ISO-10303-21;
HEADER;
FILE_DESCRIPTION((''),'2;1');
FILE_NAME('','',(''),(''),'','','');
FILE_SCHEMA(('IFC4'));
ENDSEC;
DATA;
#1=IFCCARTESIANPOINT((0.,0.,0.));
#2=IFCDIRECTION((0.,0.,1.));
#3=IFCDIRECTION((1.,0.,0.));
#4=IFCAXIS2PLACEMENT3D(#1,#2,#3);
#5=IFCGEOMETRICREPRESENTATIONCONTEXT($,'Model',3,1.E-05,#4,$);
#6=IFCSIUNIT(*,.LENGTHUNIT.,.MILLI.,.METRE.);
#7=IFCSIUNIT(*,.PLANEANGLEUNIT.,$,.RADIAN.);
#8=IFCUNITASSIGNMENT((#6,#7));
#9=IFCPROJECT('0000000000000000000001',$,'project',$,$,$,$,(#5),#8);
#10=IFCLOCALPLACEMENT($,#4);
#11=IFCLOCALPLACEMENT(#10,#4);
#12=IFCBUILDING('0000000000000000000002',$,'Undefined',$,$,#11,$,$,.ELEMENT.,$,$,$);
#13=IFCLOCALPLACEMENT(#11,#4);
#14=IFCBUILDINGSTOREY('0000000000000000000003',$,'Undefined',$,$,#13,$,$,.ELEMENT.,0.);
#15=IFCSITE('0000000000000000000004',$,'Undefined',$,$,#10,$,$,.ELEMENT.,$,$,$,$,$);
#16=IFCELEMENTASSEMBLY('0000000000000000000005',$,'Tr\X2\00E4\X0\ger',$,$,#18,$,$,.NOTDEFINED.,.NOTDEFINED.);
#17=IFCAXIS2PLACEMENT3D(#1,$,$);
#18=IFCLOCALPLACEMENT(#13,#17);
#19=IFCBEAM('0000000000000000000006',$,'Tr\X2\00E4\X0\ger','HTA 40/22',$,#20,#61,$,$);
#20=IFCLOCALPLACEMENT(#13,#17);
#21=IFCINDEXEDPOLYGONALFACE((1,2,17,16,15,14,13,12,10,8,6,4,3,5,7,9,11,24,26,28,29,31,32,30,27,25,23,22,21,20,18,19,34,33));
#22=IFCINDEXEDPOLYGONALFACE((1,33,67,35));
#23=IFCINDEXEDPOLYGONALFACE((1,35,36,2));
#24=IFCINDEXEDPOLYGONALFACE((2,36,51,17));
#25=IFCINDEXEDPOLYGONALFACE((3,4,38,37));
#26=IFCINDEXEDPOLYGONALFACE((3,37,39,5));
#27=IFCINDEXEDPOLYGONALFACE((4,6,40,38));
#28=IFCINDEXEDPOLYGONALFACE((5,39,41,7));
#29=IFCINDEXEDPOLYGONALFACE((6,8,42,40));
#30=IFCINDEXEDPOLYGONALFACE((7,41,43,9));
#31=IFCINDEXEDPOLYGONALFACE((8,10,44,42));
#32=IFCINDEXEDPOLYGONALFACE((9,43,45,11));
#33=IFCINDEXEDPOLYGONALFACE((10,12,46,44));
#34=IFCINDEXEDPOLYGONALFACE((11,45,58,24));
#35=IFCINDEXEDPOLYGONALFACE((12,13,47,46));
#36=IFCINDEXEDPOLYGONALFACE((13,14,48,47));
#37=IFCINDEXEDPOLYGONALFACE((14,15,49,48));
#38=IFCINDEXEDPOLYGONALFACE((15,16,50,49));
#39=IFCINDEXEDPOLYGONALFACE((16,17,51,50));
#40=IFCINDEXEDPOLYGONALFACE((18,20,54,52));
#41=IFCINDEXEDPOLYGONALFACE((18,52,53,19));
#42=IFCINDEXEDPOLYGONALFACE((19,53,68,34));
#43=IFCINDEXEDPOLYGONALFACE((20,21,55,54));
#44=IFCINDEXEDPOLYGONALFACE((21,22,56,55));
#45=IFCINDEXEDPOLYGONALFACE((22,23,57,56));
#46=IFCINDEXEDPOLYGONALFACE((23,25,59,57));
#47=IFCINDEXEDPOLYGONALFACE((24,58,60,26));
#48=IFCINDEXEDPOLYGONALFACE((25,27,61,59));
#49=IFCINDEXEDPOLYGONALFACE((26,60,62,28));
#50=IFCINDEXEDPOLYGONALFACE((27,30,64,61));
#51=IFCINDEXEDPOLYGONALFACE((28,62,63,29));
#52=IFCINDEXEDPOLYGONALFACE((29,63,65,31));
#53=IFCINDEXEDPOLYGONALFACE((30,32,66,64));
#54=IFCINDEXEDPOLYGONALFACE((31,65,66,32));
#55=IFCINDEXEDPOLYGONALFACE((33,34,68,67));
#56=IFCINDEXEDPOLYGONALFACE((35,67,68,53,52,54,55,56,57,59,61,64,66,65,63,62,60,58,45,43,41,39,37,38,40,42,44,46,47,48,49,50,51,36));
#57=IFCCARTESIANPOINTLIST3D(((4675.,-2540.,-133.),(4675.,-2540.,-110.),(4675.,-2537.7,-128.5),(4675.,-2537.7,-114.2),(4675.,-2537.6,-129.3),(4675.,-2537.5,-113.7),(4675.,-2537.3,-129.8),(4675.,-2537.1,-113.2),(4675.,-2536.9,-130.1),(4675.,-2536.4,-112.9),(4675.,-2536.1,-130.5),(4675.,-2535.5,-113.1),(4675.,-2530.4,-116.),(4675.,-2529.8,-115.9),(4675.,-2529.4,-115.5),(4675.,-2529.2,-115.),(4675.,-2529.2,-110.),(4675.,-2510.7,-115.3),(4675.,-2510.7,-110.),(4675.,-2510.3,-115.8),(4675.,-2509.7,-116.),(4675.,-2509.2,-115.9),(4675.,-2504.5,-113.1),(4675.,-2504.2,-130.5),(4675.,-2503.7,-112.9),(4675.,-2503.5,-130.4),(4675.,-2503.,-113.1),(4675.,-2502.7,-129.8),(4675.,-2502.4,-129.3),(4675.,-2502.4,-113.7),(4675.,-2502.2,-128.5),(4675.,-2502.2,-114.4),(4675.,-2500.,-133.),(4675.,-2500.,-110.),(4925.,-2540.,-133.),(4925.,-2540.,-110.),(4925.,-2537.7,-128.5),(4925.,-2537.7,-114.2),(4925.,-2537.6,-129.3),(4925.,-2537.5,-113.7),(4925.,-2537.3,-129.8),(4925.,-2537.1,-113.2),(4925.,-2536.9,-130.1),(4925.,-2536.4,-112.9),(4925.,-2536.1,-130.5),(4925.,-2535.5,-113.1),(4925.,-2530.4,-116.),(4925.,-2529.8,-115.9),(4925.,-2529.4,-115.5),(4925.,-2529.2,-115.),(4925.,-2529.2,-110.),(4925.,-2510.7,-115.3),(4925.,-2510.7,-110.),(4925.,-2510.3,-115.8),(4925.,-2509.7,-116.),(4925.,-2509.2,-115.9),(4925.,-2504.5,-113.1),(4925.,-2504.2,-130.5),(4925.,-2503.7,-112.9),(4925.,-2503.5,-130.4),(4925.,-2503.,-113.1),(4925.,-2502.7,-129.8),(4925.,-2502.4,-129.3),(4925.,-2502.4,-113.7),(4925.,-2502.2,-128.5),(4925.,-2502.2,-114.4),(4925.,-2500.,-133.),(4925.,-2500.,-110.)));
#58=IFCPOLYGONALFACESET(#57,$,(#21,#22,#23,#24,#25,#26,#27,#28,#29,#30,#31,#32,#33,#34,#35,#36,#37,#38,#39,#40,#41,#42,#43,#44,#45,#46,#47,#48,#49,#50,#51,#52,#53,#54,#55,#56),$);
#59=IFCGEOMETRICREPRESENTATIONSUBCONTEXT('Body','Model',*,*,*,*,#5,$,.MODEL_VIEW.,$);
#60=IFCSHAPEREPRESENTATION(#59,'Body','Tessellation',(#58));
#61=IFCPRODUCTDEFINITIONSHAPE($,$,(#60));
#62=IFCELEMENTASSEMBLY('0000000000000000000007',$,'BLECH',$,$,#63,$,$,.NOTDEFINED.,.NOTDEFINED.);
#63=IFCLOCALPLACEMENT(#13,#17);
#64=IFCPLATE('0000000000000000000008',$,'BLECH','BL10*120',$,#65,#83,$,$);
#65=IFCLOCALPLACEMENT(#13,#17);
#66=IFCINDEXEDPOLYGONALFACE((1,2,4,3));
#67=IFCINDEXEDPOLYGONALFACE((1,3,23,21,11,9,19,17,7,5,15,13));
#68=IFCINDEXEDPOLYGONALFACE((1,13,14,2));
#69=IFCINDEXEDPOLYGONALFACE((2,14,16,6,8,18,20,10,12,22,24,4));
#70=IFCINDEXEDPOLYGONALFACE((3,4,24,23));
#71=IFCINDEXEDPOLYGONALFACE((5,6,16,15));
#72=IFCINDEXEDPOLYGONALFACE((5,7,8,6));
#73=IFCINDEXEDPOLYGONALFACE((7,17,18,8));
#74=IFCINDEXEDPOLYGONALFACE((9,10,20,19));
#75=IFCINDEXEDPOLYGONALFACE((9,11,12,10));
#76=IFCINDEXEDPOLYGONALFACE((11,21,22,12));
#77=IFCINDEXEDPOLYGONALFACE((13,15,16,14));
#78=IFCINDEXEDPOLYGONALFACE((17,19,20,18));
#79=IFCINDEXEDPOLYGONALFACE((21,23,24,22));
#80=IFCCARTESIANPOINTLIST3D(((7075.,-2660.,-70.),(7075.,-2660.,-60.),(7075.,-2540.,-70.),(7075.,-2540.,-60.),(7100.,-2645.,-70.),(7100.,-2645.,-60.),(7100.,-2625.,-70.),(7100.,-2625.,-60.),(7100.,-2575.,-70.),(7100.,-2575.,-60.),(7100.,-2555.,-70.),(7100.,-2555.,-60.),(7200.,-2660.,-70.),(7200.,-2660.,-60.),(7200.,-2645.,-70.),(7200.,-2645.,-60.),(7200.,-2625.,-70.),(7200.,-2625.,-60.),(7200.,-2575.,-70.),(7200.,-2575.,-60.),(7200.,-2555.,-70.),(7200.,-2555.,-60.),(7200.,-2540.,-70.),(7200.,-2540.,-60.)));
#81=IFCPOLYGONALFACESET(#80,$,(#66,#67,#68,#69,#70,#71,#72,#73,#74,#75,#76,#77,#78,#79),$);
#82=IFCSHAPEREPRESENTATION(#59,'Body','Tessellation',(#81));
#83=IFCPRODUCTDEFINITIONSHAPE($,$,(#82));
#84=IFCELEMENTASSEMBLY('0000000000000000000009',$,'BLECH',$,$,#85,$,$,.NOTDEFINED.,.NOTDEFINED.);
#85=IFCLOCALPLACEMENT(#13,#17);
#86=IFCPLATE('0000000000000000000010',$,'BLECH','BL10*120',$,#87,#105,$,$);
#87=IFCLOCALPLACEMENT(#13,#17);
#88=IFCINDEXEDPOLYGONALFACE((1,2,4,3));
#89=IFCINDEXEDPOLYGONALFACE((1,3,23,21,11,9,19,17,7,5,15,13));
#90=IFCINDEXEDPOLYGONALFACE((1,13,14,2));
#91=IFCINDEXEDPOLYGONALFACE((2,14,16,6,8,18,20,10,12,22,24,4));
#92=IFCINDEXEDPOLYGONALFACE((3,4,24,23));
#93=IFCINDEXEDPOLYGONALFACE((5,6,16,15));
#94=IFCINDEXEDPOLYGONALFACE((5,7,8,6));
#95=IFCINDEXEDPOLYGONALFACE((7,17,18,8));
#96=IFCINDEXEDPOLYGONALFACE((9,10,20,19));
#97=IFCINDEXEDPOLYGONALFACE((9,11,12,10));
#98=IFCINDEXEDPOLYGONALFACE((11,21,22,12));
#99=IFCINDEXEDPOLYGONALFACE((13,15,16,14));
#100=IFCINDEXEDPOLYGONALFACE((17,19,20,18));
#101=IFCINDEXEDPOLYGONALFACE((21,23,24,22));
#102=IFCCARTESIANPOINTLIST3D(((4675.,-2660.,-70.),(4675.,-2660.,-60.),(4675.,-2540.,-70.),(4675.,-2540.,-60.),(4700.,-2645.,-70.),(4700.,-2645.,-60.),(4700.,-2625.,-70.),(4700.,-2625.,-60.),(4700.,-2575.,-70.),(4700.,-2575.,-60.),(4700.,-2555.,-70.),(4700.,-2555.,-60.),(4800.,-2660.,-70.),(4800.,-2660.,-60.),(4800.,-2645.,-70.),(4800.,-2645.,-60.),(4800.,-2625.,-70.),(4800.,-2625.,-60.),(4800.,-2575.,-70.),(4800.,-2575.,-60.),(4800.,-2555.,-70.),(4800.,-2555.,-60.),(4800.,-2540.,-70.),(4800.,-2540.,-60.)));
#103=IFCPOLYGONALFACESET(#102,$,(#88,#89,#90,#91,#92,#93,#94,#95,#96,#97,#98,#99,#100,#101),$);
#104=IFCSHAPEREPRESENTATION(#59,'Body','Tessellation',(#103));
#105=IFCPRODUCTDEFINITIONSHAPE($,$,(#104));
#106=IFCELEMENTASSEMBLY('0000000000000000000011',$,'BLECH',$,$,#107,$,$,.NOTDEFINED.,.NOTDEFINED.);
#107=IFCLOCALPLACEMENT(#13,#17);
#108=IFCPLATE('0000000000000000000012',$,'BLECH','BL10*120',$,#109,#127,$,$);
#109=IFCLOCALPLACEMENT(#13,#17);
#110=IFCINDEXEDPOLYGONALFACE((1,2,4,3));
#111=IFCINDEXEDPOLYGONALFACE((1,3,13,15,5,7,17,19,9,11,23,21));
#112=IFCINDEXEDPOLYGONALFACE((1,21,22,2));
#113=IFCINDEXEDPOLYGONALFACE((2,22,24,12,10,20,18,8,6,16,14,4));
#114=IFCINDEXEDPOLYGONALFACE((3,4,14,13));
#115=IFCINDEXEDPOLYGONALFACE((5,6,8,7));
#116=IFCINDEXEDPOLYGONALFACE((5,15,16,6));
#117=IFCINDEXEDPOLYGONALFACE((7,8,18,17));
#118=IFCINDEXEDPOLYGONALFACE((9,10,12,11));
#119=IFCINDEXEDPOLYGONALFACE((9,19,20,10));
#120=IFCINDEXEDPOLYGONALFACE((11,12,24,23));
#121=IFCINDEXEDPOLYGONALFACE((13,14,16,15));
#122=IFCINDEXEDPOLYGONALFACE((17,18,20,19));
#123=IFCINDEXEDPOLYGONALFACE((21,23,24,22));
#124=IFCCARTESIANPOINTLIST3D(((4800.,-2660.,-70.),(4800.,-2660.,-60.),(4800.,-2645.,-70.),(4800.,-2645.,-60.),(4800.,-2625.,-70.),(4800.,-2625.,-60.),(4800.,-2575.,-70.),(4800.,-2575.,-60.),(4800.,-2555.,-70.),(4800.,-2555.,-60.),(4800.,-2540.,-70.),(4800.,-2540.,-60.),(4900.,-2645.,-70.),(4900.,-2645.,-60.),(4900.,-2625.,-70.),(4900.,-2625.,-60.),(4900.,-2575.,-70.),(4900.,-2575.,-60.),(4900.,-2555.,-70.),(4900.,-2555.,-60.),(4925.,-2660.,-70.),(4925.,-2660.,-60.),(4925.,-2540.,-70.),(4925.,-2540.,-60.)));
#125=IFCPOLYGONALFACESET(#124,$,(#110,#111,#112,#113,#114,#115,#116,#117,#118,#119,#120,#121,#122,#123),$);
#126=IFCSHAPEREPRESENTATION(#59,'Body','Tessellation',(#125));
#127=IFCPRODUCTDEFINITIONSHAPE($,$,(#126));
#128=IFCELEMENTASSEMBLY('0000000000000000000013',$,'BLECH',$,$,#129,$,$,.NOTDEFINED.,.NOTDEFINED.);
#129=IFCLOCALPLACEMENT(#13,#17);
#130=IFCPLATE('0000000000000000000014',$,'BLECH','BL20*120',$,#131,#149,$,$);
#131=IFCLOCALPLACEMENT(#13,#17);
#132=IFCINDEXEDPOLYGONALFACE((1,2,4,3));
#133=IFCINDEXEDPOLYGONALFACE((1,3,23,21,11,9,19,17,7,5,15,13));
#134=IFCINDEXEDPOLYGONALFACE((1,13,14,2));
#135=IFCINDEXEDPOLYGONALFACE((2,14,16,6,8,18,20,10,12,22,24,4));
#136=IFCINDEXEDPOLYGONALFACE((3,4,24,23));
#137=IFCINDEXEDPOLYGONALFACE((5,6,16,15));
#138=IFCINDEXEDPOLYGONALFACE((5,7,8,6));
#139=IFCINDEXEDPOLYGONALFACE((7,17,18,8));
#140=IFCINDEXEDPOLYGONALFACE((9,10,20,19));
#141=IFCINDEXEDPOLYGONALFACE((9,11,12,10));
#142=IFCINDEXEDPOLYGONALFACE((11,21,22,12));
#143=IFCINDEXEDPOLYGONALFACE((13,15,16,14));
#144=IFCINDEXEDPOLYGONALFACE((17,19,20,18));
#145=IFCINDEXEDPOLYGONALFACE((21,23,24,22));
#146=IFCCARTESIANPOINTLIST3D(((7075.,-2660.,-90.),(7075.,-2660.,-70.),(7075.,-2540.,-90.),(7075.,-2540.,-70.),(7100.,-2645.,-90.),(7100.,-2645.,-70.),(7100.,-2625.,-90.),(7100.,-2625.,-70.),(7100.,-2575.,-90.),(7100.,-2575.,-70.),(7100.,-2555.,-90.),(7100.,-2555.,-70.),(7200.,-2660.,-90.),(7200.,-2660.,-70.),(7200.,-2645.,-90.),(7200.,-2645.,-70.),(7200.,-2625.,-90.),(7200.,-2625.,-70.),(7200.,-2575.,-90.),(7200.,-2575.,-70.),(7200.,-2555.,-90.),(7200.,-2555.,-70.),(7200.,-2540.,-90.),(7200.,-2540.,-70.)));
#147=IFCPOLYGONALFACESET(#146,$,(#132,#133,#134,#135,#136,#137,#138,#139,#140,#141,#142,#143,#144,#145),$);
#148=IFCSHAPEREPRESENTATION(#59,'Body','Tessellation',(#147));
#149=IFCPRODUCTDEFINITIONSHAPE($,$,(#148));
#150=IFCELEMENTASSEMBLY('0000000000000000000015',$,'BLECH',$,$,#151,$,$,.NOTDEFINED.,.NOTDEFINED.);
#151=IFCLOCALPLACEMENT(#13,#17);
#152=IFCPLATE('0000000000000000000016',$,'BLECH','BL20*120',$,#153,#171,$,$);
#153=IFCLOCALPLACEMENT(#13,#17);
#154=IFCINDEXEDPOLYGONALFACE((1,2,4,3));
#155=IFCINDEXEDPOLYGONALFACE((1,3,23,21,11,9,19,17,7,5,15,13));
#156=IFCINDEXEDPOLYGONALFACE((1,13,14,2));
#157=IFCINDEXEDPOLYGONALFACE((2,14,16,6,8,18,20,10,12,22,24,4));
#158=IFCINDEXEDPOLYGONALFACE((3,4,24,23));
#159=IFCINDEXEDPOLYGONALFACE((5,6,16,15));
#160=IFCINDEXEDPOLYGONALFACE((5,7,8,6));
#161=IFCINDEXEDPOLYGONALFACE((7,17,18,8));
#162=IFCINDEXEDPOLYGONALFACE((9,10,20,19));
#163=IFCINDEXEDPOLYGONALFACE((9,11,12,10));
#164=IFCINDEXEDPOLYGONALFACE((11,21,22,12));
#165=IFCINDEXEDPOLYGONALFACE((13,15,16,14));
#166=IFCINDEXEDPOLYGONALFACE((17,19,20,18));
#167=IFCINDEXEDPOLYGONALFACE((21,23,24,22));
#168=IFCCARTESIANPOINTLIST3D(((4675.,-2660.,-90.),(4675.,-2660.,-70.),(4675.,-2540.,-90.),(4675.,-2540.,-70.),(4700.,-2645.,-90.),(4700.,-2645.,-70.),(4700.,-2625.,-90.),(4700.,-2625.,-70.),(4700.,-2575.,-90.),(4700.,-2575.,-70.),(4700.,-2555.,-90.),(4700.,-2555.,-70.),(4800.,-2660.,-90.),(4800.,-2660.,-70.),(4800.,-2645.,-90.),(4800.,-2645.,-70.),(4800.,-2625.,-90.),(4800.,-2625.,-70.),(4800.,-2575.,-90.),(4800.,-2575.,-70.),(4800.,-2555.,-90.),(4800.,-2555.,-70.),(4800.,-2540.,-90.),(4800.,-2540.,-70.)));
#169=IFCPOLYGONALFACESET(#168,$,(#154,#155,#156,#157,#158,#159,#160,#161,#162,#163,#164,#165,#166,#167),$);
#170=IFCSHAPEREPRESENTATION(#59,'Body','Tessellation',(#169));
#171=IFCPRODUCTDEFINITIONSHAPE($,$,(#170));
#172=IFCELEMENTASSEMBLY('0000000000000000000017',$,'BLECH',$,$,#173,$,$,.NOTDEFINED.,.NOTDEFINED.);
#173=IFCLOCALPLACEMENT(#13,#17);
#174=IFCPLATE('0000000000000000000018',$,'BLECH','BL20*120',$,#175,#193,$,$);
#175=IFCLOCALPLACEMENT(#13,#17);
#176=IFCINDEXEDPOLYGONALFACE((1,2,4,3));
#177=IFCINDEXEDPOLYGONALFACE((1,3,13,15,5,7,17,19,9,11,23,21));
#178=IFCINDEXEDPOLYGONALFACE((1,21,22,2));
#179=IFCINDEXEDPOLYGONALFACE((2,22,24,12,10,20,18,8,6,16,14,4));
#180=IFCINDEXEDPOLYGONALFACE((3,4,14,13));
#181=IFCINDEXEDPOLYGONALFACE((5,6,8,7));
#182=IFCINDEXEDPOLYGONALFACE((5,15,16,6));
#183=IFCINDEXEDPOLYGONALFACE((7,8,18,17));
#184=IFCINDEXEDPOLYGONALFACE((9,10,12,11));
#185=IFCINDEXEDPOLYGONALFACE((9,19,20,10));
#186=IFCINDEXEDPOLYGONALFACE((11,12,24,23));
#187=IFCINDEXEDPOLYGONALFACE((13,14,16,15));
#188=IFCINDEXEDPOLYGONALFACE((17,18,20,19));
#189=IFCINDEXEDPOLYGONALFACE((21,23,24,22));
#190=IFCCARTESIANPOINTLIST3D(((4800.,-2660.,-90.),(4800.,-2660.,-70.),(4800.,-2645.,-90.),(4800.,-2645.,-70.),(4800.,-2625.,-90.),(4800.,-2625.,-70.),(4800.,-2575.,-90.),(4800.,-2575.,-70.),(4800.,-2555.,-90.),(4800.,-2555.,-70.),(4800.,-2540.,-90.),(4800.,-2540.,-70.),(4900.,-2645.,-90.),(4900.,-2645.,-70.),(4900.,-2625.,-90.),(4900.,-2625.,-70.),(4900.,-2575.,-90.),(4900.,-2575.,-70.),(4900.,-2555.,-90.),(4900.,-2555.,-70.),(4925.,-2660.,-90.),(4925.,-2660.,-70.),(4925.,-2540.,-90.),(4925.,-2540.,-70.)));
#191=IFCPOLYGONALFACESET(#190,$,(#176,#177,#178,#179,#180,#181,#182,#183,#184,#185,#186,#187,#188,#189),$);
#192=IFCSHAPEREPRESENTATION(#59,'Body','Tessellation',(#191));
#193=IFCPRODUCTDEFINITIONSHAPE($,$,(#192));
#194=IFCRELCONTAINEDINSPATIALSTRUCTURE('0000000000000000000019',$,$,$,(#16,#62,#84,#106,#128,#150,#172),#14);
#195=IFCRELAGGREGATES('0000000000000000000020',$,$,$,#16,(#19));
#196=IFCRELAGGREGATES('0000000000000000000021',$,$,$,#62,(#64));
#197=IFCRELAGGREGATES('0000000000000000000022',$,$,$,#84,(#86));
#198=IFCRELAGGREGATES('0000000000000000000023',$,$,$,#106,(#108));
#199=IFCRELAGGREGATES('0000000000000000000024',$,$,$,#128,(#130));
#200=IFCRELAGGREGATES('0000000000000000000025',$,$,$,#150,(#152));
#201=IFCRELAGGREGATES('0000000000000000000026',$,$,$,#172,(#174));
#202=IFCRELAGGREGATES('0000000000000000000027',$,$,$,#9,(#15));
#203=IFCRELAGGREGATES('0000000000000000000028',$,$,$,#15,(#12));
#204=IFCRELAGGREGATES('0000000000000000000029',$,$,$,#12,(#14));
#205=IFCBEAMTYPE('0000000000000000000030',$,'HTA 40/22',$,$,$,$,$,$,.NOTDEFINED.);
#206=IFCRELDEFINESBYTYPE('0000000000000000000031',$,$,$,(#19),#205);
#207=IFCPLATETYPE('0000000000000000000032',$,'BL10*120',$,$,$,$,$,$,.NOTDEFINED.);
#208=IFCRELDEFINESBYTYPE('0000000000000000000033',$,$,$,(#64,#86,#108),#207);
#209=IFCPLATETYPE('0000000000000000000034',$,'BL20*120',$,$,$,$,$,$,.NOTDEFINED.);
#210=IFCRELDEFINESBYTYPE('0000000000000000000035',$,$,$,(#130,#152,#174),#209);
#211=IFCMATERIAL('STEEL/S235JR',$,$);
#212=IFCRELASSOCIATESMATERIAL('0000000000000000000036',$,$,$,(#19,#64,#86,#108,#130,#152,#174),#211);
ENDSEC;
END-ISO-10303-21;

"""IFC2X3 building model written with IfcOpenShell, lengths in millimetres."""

from ifc_helpers import new_model, si_unit, frame, origin_with_axes, place, context, subcontext, project, spatial, polyline, outline, extrude, material, type_object, element, aggregate, save


model = new_model("IFC2X3")

# Units and contexts
model_context = context("Model", 3, precision=1e-05, world=origin_with_axes())
body_context = subcontext(model_context, "Body", "Model", "MODEL_VIEW")
ifc_project = project(units=[si_unit("LENGTHUNIT", "METRE", prefix="MILLI"), si_unit("PLANEANGLEUNIT", "RADIAN")], contexts=[model_context])

# Site, building, storey
site_placement = place(None, origin_with_axes())
site = spatial("IfcSite", under=ifc_project, at=site_placement, Name="Undefined", CompositionType="ELEMENT")
building_placement = place(site_placement, origin_with_axes())
building = spatial("IfcBuilding", under=site, at=building_placement, Name="Undefined", CompositionType="ELEMENT")
storey_placement = place(building_placement, origin_with_axes())
storey = spatial("IfcBuildingStorey", under=building, at=storey_placement, Name="Undefined", CompositionType="ELEMENT", Elevation=0.0)

# Element assembly, beam
assembly_1_placement = place(storey_placement, origin_with_axes())
assembly_1 = element("IfcElementAssembly", 1, at=assembly_1_placement, inside=storey, Name="Träger", AssemblyPlace="NOTDEFINED", PredefinedType="NOTDEFINED")
ifc_material = material(Name="STEEL/S235JR")
beam_type = type_object("IfcBeamType", Name="HTA 40/22", PredefinedType="NOTDEFINED")
beam_placement = place(assembly_1_placement, frame((4925.0, -2520.0, -121.5), z_axis=(0.0, 0.0, -1.0), x_axis=(-1.0, 0.0, 0.0)))
beam = element("IfcBeam", 2, at=beam_placement, type_object=beam_type, material=ifc_material, Name="Träger", Description="HTA 40/22", context=body_context, shape_type="SweptSolid", body=[
    extrude(outline(polyline([(-9.3, -6.2), (-9.2, -11.5), (-20.0, -11.5), (-20.0, 11.5), (20.0, 11.5), (20.0, -11.5), (9.2, -11.5), (9.2, -6.5), (9.4, -6.0), (9.8, -5.6), (10.4, -5.5), (15.5, -8.4), (16.4, -8.6), (17.1, -8.3), (17.5, -7.8), (17.7, -7.3), (17.8, 7.0), (17.6, 7.8), (17.3, 8.3), (16.9, 8.6), (16.1, 9.0), (-15.8, 9.0), (-16.5, 8.9), (-17.3, 8.3), (-17.6, 7.8), (-17.8, 7.0), (-17.8, -7.1), (-17.5, -7.8), (-17.0, -8.4), (-16.2, -8.6), (-15.5, -8.4), (-10.8, -5.6), (-10.2, -5.5), (-9.7, -5.7), (-9.3, -6.2)])), frame((250.0, 0.0, 0.0), z_axis=(-1.0, 0.0, 0.0), x_axis=(0.0, -1.0, 0.0)), (0.0, 0.0, 1.0), 250.0),
])
aggregate(assembly_1, [beam])

# Element assemblies, plates
assembly_2_placement = place(storey_placement, origin_with_axes())
assembly_2 = element("IfcElementAssembly", 3, at=assembly_2_placement, inside=storey, Name="BLECH", AssemblyPlace="NOTDEFINED", PredefinedType="NOTDEFINED")
plate_type_1 = type_object("IfcPlateType", Name="BL10*120", PredefinedType="NOTDEFINED")
plate_1_placement = place(assembly_2_placement, frame((7075.0, -2540.0, -65.0), z_axis=(0.0, 0.0, -1.0), x_axis=(1.0, 0.0, 0.0)))
plate_1 = element("IfcPlate", 4, at=plate_1_placement, type_object=plate_type_1, material=ifc_material, Name="BLECH", Description="BL10*120", context=body_context, shape_type="SweptSolid", body=[
    extrude(outline(polyline([(0.0, 0.0), (125.0, 0.0), (125.0, 15.0), (25.0, 15.0), (25.0, 35.0), (125.0, 35.0), (125.0, 85.0), (25.0, 85.0), (25.0, 105.0), (125.0, 105.0), (125.0, 120.0), (0.0, 120.0), (0.0, 0.0)])), frame((0.0, 0.0, -5.0), z_axis=(0.0, 0.0, 1.0), x_axis=(1.0, 0.0, 0.0)), (0.0, 0.0, 1.0), 10.0),
])
aggregate(assembly_2, [plate_1])
assembly_3_placement = place(storey_placement, origin_with_axes())
assembly_3 = element("IfcElementAssembly", 5, at=assembly_3_placement, inside=storey, Name="BLECH", AssemblyPlace="NOTDEFINED", PredefinedType="NOTDEFINED")
plate_2_placement = place(assembly_3_placement, frame((4675.0, -2540.0, -65.0), z_axis=(0.0, 0.0, -1.0), x_axis=(1.0, 0.0, 0.0)))
plate_2 = element("IfcPlate", 6, at=plate_2_placement, type_object=plate_type_1, material=ifc_material, Name="BLECH", Description="BL10*120", context=body_context, shape_type="SweptSolid", body=[
    extrude(outline(polyline([(0.0, 0.0), (125.0, 0.0), (125.0, 15.0), (25.0, 15.0), (25.0, 35.0), (125.0, 35.0), (125.0, 85.0), (25.0, 85.0), (25.0, 105.0), (125.0, 105.0), (125.0, 120.0), (0.0, 120.0), (0.0, 0.0)])), frame((0.0, 0.0, -5.0), z_axis=(0.0, 0.0, 1.0), x_axis=(1.0, 0.0, 0.0)), (0.0, 0.0, 1.0), 10.0),
])
aggregate(assembly_3, [plate_2])
assembly_4_placement = place(storey_placement, origin_with_axes())
assembly_4 = element("IfcElementAssembly", 7, at=assembly_4_placement, inside=storey, Name="BLECH", AssemblyPlace="NOTDEFINED", PredefinedType="NOTDEFINED")
plate_3_placement = place(assembly_4_placement, frame((4925.0, -2540.0, -65.0), z_axis=(0.0, 0.0, 1.0), x_axis=(-1.0, 0.0, 0.0)))
plate_3 = element("IfcPlate", 8, at=plate_3_placement, type_object=plate_type_1, material=ifc_material, Name="BLECH", Description="BL10*120", context=body_context, shape_type="SweptSolid", body=[
    extrude(outline(polyline([(0.0, 0.0), (125.0, 0.0), (125.0, 15.0), (25.0, 15.0), (25.0, 35.0), (125.0, 35.0), (125.0, 85.0), (25.0, 85.0), (25.0, 105.0), (125.0, 105.0), (125.0, 120.0), (0.0, 120.0), (0.0, 0.0)])), frame((0.0, 0.0, -5.0), z_axis=(0.0, 0.0, 1.0), x_axis=(1.0, 0.0, 0.0)), (0.0, 0.0, 1.0), 10.0),
])
aggregate(assembly_4, [plate_3])
assembly_5_placement = place(storey_placement, origin_with_axes())
assembly_5 = element("IfcElementAssembly", 9, at=assembly_5_placement, inside=storey, Name="BLECH", AssemblyPlace="NOTDEFINED", PredefinedType="NOTDEFINED")
plate_type_2 = type_object("IfcPlateType", Name="BL20*120", PredefinedType="NOTDEFINED")
plate_4_placement = place(assembly_5_placement, frame((7075.0, -2540.0, -80.0), z_axis=(0.0, 0.0, -1.0), x_axis=(1.0, 0.0, 0.0)))
plate_4 = element("IfcPlate", 10, at=plate_4_placement, type_object=plate_type_2, material=ifc_material, Name="BLECH", Description="BL20*120", context=body_context, shape_type="SweptSolid", body=[
    extrude(outline(polyline([(0.0, 0.0), (125.0, 0.0), (125.0, 15.0), (25.0, 15.0), (25.0, 35.0), (125.0, 35.0), (125.0, 85.0), (25.0, 85.0), (25.0, 105.0), (125.0, 105.0), (125.0, 120.0), (0.0, 120.0), (0.0, 0.0)])), frame((0.0, 0.0, -10.0), z_axis=(0.0, 0.0, 1.0), x_axis=(1.0, 0.0, 0.0)), (0.0, 0.0, 1.0), 20.0),
])
aggregate(assembly_5, [plate_4])
assembly_6_placement = place(storey_placement, origin_with_axes())
assembly_6 = element("IfcElementAssembly", 11, at=assembly_6_placement, inside=storey, Name="BLECH", AssemblyPlace="NOTDEFINED", PredefinedType="NOTDEFINED")
plate_5_placement = place(assembly_6_placement, frame((4675.0, -2540.0, -80.0), z_axis=(0.0, 0.0, -1.0), x_axis=(1.0, 0.0, 0.0)))
plate_5 = element("IfcPlate", 12, at=plate_5_placement, type_object=plate_type_2, material=ifc_material, Name="BLECH", Description="BL20*120", context=body_context, shape_type="SweptSolid", body=[
    extrude(outline(polyline([(0.0, 0.0), (125.0, 0.0), (125.0, 15.0), (25.0, 15.0), (25.0, 35.0), (125.0, 35.0), (125.0, 85.0), (25.0, 85.0), (25.0, 105.0), (125.0, 105.0), (125.0, 120.0), (0.0, 120.0), (0.0, 0.0)])), frame((0.0, 0.0, -10.0), z_axis=(0.0, 0.0, 1.0), x_axis=(1.0, 0.0, 0.0)), (0.0, 0.0, 1.0), 20.0),
])
aggregate(assembly_6, [plate_5])
assembly_7_placement = place(storey_placement, origin_with_axes())
assembly_7 = element("IfcElementAssembly", 13, at=assembly_7_placement, inside=storey, Name="BLECH", AssemblyPlace="NOTDEFINED", PredefinedType="NOTDEFINED")
plate_6_placement = place(assembly_7_placement, frame((4925.0, -2540.0, -80.0), z_axis=(0.0, 0.0, 1.0), x_axis=(-1.0, 0.0, 0.0)))
plate_6 = element("IfcPlate", 14, at=plate_6_placement, type_object=plate_type_2, material=ifc_material, Name="BLECH", Description="BL20*120", context=body_context, shape_type="SweptSolid", body=[
    extrude(outline(polyline([(0.0, 0.0), (125.0, 0.0), (125.0, 15.0), (25.0, 15.0), (25.0, 35.0), (125.0, 35.0), (125.0, 85.0), (25.0, 85.0), (25.0, 105.0), (125.0, 105.0), (125.0, 120.0), (0.0, 120.0), (0.0, 0.0)])), frame((0.0, 0.0, -10.0), z_axis=(0.0, 0.0, 1.0), x_axis=(1.0, 0.0, 0.0)), (0.0, 0.0, 1.0), 20.0),
])
aggregate(assembly_7, [plate_6])

save(model, "model.ifc")
